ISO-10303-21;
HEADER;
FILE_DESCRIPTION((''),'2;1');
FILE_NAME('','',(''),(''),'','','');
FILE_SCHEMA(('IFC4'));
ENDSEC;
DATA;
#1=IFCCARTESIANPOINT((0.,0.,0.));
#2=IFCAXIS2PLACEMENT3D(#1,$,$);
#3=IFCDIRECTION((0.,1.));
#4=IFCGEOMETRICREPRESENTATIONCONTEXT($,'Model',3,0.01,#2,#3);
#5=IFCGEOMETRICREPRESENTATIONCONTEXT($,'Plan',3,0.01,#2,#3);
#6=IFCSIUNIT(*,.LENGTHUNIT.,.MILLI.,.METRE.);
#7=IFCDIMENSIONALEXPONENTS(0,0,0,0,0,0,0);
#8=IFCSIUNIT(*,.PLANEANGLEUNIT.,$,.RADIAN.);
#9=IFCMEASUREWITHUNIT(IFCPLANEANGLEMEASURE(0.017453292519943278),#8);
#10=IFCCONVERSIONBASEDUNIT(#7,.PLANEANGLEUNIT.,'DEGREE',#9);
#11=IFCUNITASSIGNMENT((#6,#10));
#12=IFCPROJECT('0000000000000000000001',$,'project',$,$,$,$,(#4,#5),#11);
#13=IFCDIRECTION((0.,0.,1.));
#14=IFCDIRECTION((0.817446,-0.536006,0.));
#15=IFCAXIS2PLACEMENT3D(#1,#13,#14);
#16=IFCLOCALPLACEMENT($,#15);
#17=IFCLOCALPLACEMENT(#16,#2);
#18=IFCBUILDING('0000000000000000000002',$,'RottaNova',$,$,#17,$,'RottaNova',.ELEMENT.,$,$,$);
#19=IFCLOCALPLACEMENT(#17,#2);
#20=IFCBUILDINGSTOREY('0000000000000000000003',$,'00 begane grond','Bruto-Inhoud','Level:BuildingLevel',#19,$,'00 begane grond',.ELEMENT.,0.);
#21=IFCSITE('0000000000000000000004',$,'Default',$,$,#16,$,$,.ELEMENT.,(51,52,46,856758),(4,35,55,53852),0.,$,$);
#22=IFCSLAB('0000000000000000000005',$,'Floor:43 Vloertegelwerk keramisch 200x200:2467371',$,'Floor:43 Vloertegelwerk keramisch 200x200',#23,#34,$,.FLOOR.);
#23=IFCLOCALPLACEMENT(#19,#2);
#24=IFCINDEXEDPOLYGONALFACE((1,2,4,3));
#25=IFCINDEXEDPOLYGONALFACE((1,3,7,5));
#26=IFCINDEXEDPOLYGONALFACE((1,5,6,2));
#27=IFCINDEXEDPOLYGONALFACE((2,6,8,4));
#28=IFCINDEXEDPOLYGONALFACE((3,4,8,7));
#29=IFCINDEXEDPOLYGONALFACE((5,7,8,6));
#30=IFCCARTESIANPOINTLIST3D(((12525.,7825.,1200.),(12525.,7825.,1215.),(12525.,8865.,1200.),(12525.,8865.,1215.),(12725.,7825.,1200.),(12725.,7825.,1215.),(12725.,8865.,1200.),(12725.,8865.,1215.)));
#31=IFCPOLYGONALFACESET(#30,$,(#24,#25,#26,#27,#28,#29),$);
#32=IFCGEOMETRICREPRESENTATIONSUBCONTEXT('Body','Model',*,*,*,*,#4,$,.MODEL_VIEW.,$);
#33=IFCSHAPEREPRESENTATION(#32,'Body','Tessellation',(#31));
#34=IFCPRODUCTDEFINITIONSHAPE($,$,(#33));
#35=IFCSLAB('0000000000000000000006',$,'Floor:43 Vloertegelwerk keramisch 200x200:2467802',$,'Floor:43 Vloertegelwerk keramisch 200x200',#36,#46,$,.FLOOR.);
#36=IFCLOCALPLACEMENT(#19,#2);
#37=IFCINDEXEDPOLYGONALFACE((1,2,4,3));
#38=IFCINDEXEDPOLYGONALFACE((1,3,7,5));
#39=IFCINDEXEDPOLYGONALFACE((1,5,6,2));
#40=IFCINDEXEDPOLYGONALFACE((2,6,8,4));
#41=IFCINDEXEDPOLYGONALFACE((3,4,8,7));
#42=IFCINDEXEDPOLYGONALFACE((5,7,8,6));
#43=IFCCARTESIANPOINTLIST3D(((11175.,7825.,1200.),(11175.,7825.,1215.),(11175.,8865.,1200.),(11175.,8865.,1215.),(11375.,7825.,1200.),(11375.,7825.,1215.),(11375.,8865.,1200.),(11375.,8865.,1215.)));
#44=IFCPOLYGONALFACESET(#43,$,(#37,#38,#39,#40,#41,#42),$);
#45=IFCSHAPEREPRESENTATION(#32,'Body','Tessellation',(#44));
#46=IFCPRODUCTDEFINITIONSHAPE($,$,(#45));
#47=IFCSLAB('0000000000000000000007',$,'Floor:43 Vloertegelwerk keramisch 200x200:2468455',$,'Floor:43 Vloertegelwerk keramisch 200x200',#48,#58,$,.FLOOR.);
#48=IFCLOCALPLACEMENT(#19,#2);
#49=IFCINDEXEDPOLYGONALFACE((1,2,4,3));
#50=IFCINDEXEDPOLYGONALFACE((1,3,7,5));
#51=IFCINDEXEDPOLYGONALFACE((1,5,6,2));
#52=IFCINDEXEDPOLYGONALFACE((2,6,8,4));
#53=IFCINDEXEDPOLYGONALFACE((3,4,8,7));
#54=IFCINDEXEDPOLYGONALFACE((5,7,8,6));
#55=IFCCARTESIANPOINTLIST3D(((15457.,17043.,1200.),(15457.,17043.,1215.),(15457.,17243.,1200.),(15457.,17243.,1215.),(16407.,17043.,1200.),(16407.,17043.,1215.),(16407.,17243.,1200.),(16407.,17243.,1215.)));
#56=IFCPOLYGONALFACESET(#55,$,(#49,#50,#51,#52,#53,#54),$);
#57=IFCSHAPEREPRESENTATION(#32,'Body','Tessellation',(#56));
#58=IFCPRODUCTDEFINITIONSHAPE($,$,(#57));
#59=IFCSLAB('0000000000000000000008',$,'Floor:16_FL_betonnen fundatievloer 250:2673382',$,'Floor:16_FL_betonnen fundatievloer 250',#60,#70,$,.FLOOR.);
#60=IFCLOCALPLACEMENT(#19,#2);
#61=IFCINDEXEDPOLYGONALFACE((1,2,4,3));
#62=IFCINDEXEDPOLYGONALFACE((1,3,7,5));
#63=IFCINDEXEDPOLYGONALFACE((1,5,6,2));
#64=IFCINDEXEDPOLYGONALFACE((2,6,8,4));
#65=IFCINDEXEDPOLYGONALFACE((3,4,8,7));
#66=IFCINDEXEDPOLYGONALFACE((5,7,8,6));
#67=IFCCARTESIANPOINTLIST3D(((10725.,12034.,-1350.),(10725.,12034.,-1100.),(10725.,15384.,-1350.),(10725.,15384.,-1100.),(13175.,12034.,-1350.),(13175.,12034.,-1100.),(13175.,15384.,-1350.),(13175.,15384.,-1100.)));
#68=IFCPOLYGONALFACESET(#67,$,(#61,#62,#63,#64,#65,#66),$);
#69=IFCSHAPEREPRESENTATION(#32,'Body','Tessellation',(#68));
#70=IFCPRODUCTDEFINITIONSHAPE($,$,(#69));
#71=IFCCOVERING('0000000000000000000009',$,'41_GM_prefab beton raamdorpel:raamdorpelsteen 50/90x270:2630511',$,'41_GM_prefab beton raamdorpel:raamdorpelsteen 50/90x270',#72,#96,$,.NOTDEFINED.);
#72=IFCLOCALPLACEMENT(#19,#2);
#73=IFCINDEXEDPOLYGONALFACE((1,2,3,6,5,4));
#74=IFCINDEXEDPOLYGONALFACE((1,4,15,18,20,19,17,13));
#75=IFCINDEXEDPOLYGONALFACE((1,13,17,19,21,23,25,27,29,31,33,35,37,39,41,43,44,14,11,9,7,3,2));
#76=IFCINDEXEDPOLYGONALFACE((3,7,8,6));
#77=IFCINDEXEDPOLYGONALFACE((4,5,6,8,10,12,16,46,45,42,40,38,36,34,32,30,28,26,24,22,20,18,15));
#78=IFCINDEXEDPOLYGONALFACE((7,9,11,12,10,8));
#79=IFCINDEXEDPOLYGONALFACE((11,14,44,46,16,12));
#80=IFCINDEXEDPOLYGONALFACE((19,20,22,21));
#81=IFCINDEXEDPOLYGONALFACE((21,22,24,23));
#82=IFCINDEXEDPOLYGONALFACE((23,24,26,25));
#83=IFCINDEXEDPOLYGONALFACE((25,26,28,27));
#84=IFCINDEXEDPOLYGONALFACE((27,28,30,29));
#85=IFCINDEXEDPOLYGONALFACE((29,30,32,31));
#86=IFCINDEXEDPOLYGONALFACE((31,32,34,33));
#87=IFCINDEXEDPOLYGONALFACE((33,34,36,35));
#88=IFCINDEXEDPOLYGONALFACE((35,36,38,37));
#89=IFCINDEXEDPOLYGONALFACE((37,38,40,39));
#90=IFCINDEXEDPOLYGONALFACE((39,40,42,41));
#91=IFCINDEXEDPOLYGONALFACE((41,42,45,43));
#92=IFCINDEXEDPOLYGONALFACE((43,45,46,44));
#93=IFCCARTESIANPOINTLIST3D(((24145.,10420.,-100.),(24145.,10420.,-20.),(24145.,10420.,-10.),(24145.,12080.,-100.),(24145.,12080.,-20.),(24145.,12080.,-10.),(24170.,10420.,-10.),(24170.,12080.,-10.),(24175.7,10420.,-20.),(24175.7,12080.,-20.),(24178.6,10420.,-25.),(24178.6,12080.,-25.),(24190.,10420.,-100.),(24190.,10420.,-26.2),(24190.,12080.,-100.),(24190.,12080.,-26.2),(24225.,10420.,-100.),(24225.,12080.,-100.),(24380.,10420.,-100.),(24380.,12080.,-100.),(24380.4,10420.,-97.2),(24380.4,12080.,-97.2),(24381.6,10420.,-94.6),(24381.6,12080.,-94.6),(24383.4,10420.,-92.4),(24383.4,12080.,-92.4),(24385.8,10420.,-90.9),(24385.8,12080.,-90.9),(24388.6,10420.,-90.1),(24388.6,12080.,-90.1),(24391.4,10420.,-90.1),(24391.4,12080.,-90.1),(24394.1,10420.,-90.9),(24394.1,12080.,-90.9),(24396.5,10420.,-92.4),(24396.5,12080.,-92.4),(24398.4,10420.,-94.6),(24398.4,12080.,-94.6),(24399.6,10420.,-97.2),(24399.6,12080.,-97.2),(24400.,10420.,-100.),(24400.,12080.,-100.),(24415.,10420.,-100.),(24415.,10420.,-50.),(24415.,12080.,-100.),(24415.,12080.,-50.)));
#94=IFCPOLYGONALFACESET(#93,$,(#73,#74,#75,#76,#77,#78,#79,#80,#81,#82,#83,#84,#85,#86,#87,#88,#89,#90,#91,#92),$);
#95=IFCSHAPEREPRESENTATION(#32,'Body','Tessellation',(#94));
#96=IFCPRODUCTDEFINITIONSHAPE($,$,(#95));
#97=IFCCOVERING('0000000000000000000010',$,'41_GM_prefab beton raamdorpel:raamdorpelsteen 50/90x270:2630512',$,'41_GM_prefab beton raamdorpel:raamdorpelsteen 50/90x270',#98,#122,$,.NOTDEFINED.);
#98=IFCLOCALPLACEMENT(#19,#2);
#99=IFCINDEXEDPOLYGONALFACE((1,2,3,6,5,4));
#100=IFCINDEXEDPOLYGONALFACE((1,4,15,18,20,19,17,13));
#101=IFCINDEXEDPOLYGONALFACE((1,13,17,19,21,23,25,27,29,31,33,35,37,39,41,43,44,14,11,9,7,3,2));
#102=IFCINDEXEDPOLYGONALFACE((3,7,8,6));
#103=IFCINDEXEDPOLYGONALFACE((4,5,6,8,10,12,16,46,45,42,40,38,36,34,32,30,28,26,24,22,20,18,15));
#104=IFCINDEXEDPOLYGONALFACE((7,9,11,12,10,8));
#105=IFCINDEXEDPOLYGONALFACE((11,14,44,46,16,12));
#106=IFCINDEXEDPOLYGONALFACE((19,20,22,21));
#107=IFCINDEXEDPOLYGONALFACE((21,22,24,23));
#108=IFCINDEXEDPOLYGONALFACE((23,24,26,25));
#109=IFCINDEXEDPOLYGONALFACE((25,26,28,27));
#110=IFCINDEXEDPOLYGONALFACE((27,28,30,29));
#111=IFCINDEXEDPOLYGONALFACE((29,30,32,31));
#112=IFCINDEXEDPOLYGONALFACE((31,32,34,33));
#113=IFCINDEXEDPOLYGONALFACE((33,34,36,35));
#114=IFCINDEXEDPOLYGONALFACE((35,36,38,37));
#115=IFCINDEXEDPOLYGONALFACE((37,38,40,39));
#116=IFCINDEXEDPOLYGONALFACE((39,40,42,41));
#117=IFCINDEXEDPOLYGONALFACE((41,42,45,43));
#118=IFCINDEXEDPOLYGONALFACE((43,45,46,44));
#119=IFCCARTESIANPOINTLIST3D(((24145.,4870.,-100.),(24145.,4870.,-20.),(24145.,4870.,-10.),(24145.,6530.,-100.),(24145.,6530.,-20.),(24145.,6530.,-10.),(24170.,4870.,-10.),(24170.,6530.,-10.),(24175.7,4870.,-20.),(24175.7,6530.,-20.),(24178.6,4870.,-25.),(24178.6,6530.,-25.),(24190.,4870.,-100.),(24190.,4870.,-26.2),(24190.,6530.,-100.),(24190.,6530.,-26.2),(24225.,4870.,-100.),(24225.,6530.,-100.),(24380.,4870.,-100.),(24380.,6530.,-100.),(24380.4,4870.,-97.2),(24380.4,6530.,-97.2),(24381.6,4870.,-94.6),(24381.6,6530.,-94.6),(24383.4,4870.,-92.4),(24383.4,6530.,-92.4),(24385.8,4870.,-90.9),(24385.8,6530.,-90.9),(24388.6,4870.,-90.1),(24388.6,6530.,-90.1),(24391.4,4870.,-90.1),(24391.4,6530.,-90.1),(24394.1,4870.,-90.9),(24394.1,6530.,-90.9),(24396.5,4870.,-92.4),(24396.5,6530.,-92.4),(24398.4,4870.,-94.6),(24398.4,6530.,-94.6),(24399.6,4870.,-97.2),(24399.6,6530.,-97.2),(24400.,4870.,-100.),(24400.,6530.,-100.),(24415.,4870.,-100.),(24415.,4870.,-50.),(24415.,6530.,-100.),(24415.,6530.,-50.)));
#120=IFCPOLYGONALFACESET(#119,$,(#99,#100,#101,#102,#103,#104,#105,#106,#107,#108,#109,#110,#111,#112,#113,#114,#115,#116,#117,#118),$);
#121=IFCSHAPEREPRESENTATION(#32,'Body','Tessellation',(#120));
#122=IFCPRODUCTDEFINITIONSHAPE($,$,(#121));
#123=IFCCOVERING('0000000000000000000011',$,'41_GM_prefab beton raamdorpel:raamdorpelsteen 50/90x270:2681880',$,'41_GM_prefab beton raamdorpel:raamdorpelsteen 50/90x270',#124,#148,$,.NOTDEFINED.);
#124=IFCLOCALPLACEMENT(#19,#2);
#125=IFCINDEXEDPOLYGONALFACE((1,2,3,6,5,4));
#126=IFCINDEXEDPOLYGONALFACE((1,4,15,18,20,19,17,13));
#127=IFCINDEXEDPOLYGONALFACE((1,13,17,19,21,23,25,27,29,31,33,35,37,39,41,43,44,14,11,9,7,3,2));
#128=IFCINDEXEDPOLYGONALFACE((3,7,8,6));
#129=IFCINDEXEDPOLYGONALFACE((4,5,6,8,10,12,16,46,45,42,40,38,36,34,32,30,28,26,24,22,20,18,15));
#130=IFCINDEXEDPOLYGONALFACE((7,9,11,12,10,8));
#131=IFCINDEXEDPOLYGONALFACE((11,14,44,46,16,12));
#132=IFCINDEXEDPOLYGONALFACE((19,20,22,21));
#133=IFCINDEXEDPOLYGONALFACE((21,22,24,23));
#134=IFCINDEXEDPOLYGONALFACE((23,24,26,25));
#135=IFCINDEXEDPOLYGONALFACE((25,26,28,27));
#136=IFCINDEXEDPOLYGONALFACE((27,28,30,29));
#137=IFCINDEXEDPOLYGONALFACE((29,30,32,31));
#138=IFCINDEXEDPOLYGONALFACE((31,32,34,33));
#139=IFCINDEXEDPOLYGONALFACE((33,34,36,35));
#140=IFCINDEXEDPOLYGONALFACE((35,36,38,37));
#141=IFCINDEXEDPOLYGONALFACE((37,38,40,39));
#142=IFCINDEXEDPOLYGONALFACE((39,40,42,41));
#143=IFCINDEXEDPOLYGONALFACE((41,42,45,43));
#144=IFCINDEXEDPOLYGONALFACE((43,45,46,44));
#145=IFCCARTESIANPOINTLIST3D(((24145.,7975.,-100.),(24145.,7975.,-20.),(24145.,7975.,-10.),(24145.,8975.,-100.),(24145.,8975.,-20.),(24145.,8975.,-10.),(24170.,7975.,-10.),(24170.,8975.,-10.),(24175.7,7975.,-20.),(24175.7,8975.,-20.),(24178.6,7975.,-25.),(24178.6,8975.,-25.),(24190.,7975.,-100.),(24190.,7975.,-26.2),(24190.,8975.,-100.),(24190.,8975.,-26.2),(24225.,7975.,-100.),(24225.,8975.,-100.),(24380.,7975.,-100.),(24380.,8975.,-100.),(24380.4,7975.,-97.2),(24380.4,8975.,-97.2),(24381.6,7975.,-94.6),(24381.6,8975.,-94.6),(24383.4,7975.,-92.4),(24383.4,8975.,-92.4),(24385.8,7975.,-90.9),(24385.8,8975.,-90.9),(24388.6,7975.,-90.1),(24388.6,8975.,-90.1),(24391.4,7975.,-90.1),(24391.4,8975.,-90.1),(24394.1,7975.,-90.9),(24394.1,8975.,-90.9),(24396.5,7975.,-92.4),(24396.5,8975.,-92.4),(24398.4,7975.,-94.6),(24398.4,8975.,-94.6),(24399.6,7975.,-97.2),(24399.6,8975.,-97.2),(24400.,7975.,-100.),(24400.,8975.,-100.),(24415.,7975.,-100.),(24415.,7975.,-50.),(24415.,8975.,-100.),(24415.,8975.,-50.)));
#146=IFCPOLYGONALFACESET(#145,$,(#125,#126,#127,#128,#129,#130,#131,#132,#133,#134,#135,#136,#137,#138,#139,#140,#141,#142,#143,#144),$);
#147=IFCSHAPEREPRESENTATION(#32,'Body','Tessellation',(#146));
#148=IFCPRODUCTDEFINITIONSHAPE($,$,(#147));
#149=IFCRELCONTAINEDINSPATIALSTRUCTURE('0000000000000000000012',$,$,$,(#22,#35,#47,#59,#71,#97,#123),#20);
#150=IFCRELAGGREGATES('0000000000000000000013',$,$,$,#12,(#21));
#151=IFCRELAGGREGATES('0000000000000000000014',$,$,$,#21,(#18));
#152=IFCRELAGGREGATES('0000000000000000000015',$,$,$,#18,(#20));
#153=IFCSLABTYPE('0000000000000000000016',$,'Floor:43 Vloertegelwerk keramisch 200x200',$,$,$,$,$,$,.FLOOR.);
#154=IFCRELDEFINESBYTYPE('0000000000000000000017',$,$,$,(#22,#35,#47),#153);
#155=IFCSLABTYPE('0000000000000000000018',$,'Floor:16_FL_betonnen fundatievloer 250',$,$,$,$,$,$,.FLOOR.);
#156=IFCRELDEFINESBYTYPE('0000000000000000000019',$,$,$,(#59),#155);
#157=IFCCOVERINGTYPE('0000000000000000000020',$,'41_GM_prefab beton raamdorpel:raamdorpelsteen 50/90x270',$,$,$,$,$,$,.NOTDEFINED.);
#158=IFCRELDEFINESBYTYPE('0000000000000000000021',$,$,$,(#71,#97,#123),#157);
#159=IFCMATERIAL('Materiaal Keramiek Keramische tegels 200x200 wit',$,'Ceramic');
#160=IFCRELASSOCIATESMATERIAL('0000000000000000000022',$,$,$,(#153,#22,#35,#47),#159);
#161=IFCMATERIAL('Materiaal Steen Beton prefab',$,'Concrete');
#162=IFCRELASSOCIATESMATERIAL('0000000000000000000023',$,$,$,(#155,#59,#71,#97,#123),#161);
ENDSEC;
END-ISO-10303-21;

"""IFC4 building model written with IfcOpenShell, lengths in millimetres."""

from ifc_helpers import new_model, entity, si_unit, converted_unit, direction, frame, origin, place, context, subcontext, project, spatial, line, arc, indexed_curve, outline, extrude, material, type_object, element, save


model = new_model("IFC4")

# Units and contexts
model_context = context("Model", 3, precision=0.01, world=origin(), true_north=direction((0.0, 1.0)))
plan_context = context("Plan", 3, precision=0.01, world=origin(), true_north=direction((0.0, 1.0)))
body_context = subcontext(model_context, "Body", "Model", "MODEL_VIEW")
ifc_project = project(units=[si_unit("LENGTHUNIT", "METRE", prefix="MILLI"), converted_unit("PLANEANGLEUNIT", "DEGREE", entity("IfcPlaneAngleMeasure", 0.017453292519943278), si_unit("PLANEANGLEUNIT", "RADIAN"), dimensions=[0, 0, 0, 0, 0, 0, 0])], contexts=[model_context, plan_context])

# Site, building, storey
site_placement = place(None, frame((0.0, 0.0, 0.0), z_axis=(0.0, 0.0, 1.0), x_axis=(0.817446, -0.536006, 0.0)))
site = spatial("IfcSite", under=ifc_project, at=site_placement, Name="Default", CompositionType="ELEMENT", RefLatitude=(51, 52, 46, 856758), RefLongitude=(4, 35, 55, 53852), RefElevation=0.0)
building_placement = place(site_placement, origin())
building = spatial("IfcBuilding", under=site, at=building_placement, Name="RottaNova", LongName="RottaNova", CompositionType="ELEMENT")
storey_placement = place(building_placement, origin())
storey = spatial("IfcBuildingStorey", under=building, at=storey_placement, Name="00 begane grond", Description="Bruto-Inhoud", ObjectType="Level:BuildingLevel", LongName="00 begane grond", CompositionType="ELEMENT", Elevation=0.0)

# Slabs
ifc_material_1 = material(Name="Materiaal Keramiek Keramische tegels 200x200 wit", Category="Ceramic")
slab_type_1 = type_object("IfcSlabType", Name="Floor:43 Vloertegelwerk keramisch 200x200", PredefinedType="FLOOR", material=ifc_material_1)
slab_1_placement = place(storey_placement, origin())
element("IfcSlab", 1, at=slab_1_placement, inside=storey, type_object=slab_type_1, material=ifc_material_1, Name="Floor:43 Vloertegelwerk keramisch 200x200:2467371", ObjectType="Floor:43 Vloertegelwerk keramisch 200x200", PredefinedType="FLOOR", context=body_context, shape_type="SweptSolid", body=[
    extrude(outline(indexed_curve([(-520.0, -100.0), (520.0, -100.0), (520.0, 100.0), (-520.0, 100.0), (-520.0, -100.0)], self_intersect=False)), frame((12625.0, 8345.0, 1215.0), z_axis=(0.0, 0.0, -1.0), x_axis=(0.0, 1.0, 0.0)), (0.0, 0.0, 1.0), 15.0),
])
slab_2_placement = place(storey_placement, origin())
element("IfcSlab", 2, at=slab_2_placement, inside=storey, type_object=slab_type_1, material=ifc_material_1, Name="Floor:43 Vloertegelwerk keramisch 200x200:2467802", ObjectType="Floor:43 Vloertegelwerk keramisch 200x200", PredefinedType="FLOOR", context=body_context, shape_type="SweptSolid", body=[
    extrude(outline(indexed_curve([(-520.0, -100.0), (520.0, -100.0), (520.0, 100.0), (-520.0, 100.0), (-520.0, -100.0)], self_intersect=False)), frame((11275.0, 8345.0, 1215.0), z_axis=(0.0, 0.0, -1.0), x_axis=(0.0, 1.0, 0.0)), (0.0, 0.0, 1.0), 15.0),
])
slab_3_placement = place(storey_placement, origin())
element("IfcSlab", 3, at=slab_3_placement, inside=storey, type_object=slab_type_1, material=ifc_material_1, Name="Floor:43 Vloertegelwerk keramisch 200x200:2468455", ObjectType="Floor:43 Vloertegelwerk keramisch 200x200", PredefinedType="FLOOR", context=body_context, shape_type="SweptSolid", body=[
    extrude(outline(indexed_curve([(-100.0, -475.0), (100.0, -475.0), (100.0, 475.0), (-100.0, 475.0), (-100.0, -475.0)], self_intersect=False)), frame((15932.0, 17143.0, 1215.0), z_axis=(0.0, 0.0, -1.0), x_axis=(0.0, 1.0, 0.0)), (0.0, 0.0, 1.0), 15.0),
])
ifc_material_2 = material(Name="Materiaal Steen Beton prefab", Category="Concrete")
slab_type_2 = type_object("IfcSlabType", Name="Floor:16_FL_betonnen fundatievloer 250", PredefinedType="FLOOR", material=ifc_material_2)
slab_4_placement = place(storey_placement, origin())
element("IfcSlab", 4, at=slab_4_placement, inside=storey, type_object=slab_type_2, material=ifc_material_2, Name="Floor:16_FL_betonnen fundatievloer 250:2673382", ObjectType="Floor:16_FL_betonnen fundatievloer 250", PredefinedType="FLOOR", context=body_context, shape_type="SweptSolid", body=[
    extrude(outline(indexed_curve([(-1675.0, -1225.0), (1675.0, -1225.0), (1675.0, 1225.0), (-1675.0, 1225.0), (-1675.0, -1225.0)], self_intersect=False)), frame((11950.0, 13709.0, -1100.0), z_axis=(0.0, 0.0, -1.0), x_axis=(0.0, 1.0, 0.0)), (0.0, 0.0, 1.0), 250.0),
])

# Coverings
covering_type_1 = type_object("IfcCoveringType", Name="41_GM_prefab beton raamdorpel:raamdorpelsteen 50/90x270", PredefinedType="NOTDEFINED")
covering_1_placement = place(storey_placement, origin())
element("IfcCovering", 5, at=covering_1_placement, inside=storey, type_object=covering_type_1, material=ifc_material_2, Name="41_GM_prefab beton raamdorpel:raamdorpelsteen 50/90x270:2630511", ObjectType="41_GM_prefab beton raamdorpel:raamdorpelsteen 50/90x270", PredefinedType="NOTDEFINED", context=body_context, shape_type="SweptSolid", body=[
    extrude(outline(indexed_curve([(-79.1, -40.0), (-91.6, -61.6), (-83.0, -66.6), (-13.7, -106.6), (8.8, -67.6), (26.3, -37.3), (103.8, 96.9), (100.1, 110.6), (113.8, 114.2), (121.3, 127.2), (78.0, 152.2), (-55.1, -30.7), (-61.8, -40.0), (-67.6, -40.0)], segments=[line(1, 2, 3, 4, 5, 6, 7), arc(7, 8, 9), line(9, 10, 11, 12, 13, 14, 1)], self_intersect=False)), frame((24244.2, 10420.0, -58.6), z_axis=(0.0, -1.0, 0.0), x_axis=(0.5, 0.0, -0.866025)), (0.0, 0.0, -1.0), 1660.0),
])
covering_2_placement = place(storey_placement, origin())
element("IfcCovering", 6, at=covering_2_placement, inside=storey, type_object=covering_type_1, material=ifc_material_2, Name="41_GM_prefab beton raamdorpel:raamdorpelsteen 50/90x270:2630512", ObjectType="41_GM_prefab beton raamdorpel:raamdorpelsteen 50/90x270", PredefinedType="NOTDEFINED", context=body_context, shape_type="SweptSolid", body=[
    extrude(outline(indexed_curve([(-79.1, -40.0), (-91.6, -61.6), (-83.0, -66.6), (-13.7, -106.6), (8.8, -67.6), (26.3, -37.3), (103.8, 96.9), (100.1, 110.6), (113.8, 114.2), (121.3, 127.2), (78.0, 152.2), (-55.1, -30.7), (-61.8, -40.0), (-67.6, -40.0)], segments=[line(1, 2, 3, 4, 5, 6, 7), arc(7, 8, 9), line(9, 10, 11, 12, 13, 14, 1)], self_intersect=False)), frame((24244.2, 4870.0, -58.6), z_axis=(0.0, -1.0, 0.0), x_axis=(0.5, 0.0, -0.866025)), (0.0, 0.0, -1.0), 1660.0),
])
covering_3_placement = place(storey_placement, origin())
element("IfcCovering", 7, at=covering_3_placement, inside=storey, type_object=covering_type_1, material=ifc_material_2, Name="41_GM_prefab beton raamdorpel:raamdorpelsteen 50/90x270:2681880", ObjectType="41_GM_prefab beton raamdorpel:raamdorpelsteen 50/90x270", PredefinedType="NOTDEFINED", context=body_context, shape_type="SweptSolid", body=[
    extrude(outline(indexed_curve([(-79.1, -40.0), (-91.6, -61.6), (-83.0, -66.6), (-13.7, -106.6), (8.8, -67.6), (26.3, -37.3), (103.8, 96.9), (100.1, 110.6), (113.8, 114.2), (121.3, 127.2), (78.0, 152.2), (-55.1, -30.7), (-61.8, -40.0), (-67.6, -40.0)], segments=[line(1, 2, 3, 4, 5, 6, 7), arc(7, 8, 9), line(9, 10, 11, 12, 13, 14, 1)], self_intersect=False)), frame((24244.2, 7975.0, -58.6), z_axis=(0.0, -1.0, 0.0), x_axis=(0.5, 0.0, -0.866025)), (0.0, 0.0, -1.0), 1000.0),
])

save(model, "model.ifc")
